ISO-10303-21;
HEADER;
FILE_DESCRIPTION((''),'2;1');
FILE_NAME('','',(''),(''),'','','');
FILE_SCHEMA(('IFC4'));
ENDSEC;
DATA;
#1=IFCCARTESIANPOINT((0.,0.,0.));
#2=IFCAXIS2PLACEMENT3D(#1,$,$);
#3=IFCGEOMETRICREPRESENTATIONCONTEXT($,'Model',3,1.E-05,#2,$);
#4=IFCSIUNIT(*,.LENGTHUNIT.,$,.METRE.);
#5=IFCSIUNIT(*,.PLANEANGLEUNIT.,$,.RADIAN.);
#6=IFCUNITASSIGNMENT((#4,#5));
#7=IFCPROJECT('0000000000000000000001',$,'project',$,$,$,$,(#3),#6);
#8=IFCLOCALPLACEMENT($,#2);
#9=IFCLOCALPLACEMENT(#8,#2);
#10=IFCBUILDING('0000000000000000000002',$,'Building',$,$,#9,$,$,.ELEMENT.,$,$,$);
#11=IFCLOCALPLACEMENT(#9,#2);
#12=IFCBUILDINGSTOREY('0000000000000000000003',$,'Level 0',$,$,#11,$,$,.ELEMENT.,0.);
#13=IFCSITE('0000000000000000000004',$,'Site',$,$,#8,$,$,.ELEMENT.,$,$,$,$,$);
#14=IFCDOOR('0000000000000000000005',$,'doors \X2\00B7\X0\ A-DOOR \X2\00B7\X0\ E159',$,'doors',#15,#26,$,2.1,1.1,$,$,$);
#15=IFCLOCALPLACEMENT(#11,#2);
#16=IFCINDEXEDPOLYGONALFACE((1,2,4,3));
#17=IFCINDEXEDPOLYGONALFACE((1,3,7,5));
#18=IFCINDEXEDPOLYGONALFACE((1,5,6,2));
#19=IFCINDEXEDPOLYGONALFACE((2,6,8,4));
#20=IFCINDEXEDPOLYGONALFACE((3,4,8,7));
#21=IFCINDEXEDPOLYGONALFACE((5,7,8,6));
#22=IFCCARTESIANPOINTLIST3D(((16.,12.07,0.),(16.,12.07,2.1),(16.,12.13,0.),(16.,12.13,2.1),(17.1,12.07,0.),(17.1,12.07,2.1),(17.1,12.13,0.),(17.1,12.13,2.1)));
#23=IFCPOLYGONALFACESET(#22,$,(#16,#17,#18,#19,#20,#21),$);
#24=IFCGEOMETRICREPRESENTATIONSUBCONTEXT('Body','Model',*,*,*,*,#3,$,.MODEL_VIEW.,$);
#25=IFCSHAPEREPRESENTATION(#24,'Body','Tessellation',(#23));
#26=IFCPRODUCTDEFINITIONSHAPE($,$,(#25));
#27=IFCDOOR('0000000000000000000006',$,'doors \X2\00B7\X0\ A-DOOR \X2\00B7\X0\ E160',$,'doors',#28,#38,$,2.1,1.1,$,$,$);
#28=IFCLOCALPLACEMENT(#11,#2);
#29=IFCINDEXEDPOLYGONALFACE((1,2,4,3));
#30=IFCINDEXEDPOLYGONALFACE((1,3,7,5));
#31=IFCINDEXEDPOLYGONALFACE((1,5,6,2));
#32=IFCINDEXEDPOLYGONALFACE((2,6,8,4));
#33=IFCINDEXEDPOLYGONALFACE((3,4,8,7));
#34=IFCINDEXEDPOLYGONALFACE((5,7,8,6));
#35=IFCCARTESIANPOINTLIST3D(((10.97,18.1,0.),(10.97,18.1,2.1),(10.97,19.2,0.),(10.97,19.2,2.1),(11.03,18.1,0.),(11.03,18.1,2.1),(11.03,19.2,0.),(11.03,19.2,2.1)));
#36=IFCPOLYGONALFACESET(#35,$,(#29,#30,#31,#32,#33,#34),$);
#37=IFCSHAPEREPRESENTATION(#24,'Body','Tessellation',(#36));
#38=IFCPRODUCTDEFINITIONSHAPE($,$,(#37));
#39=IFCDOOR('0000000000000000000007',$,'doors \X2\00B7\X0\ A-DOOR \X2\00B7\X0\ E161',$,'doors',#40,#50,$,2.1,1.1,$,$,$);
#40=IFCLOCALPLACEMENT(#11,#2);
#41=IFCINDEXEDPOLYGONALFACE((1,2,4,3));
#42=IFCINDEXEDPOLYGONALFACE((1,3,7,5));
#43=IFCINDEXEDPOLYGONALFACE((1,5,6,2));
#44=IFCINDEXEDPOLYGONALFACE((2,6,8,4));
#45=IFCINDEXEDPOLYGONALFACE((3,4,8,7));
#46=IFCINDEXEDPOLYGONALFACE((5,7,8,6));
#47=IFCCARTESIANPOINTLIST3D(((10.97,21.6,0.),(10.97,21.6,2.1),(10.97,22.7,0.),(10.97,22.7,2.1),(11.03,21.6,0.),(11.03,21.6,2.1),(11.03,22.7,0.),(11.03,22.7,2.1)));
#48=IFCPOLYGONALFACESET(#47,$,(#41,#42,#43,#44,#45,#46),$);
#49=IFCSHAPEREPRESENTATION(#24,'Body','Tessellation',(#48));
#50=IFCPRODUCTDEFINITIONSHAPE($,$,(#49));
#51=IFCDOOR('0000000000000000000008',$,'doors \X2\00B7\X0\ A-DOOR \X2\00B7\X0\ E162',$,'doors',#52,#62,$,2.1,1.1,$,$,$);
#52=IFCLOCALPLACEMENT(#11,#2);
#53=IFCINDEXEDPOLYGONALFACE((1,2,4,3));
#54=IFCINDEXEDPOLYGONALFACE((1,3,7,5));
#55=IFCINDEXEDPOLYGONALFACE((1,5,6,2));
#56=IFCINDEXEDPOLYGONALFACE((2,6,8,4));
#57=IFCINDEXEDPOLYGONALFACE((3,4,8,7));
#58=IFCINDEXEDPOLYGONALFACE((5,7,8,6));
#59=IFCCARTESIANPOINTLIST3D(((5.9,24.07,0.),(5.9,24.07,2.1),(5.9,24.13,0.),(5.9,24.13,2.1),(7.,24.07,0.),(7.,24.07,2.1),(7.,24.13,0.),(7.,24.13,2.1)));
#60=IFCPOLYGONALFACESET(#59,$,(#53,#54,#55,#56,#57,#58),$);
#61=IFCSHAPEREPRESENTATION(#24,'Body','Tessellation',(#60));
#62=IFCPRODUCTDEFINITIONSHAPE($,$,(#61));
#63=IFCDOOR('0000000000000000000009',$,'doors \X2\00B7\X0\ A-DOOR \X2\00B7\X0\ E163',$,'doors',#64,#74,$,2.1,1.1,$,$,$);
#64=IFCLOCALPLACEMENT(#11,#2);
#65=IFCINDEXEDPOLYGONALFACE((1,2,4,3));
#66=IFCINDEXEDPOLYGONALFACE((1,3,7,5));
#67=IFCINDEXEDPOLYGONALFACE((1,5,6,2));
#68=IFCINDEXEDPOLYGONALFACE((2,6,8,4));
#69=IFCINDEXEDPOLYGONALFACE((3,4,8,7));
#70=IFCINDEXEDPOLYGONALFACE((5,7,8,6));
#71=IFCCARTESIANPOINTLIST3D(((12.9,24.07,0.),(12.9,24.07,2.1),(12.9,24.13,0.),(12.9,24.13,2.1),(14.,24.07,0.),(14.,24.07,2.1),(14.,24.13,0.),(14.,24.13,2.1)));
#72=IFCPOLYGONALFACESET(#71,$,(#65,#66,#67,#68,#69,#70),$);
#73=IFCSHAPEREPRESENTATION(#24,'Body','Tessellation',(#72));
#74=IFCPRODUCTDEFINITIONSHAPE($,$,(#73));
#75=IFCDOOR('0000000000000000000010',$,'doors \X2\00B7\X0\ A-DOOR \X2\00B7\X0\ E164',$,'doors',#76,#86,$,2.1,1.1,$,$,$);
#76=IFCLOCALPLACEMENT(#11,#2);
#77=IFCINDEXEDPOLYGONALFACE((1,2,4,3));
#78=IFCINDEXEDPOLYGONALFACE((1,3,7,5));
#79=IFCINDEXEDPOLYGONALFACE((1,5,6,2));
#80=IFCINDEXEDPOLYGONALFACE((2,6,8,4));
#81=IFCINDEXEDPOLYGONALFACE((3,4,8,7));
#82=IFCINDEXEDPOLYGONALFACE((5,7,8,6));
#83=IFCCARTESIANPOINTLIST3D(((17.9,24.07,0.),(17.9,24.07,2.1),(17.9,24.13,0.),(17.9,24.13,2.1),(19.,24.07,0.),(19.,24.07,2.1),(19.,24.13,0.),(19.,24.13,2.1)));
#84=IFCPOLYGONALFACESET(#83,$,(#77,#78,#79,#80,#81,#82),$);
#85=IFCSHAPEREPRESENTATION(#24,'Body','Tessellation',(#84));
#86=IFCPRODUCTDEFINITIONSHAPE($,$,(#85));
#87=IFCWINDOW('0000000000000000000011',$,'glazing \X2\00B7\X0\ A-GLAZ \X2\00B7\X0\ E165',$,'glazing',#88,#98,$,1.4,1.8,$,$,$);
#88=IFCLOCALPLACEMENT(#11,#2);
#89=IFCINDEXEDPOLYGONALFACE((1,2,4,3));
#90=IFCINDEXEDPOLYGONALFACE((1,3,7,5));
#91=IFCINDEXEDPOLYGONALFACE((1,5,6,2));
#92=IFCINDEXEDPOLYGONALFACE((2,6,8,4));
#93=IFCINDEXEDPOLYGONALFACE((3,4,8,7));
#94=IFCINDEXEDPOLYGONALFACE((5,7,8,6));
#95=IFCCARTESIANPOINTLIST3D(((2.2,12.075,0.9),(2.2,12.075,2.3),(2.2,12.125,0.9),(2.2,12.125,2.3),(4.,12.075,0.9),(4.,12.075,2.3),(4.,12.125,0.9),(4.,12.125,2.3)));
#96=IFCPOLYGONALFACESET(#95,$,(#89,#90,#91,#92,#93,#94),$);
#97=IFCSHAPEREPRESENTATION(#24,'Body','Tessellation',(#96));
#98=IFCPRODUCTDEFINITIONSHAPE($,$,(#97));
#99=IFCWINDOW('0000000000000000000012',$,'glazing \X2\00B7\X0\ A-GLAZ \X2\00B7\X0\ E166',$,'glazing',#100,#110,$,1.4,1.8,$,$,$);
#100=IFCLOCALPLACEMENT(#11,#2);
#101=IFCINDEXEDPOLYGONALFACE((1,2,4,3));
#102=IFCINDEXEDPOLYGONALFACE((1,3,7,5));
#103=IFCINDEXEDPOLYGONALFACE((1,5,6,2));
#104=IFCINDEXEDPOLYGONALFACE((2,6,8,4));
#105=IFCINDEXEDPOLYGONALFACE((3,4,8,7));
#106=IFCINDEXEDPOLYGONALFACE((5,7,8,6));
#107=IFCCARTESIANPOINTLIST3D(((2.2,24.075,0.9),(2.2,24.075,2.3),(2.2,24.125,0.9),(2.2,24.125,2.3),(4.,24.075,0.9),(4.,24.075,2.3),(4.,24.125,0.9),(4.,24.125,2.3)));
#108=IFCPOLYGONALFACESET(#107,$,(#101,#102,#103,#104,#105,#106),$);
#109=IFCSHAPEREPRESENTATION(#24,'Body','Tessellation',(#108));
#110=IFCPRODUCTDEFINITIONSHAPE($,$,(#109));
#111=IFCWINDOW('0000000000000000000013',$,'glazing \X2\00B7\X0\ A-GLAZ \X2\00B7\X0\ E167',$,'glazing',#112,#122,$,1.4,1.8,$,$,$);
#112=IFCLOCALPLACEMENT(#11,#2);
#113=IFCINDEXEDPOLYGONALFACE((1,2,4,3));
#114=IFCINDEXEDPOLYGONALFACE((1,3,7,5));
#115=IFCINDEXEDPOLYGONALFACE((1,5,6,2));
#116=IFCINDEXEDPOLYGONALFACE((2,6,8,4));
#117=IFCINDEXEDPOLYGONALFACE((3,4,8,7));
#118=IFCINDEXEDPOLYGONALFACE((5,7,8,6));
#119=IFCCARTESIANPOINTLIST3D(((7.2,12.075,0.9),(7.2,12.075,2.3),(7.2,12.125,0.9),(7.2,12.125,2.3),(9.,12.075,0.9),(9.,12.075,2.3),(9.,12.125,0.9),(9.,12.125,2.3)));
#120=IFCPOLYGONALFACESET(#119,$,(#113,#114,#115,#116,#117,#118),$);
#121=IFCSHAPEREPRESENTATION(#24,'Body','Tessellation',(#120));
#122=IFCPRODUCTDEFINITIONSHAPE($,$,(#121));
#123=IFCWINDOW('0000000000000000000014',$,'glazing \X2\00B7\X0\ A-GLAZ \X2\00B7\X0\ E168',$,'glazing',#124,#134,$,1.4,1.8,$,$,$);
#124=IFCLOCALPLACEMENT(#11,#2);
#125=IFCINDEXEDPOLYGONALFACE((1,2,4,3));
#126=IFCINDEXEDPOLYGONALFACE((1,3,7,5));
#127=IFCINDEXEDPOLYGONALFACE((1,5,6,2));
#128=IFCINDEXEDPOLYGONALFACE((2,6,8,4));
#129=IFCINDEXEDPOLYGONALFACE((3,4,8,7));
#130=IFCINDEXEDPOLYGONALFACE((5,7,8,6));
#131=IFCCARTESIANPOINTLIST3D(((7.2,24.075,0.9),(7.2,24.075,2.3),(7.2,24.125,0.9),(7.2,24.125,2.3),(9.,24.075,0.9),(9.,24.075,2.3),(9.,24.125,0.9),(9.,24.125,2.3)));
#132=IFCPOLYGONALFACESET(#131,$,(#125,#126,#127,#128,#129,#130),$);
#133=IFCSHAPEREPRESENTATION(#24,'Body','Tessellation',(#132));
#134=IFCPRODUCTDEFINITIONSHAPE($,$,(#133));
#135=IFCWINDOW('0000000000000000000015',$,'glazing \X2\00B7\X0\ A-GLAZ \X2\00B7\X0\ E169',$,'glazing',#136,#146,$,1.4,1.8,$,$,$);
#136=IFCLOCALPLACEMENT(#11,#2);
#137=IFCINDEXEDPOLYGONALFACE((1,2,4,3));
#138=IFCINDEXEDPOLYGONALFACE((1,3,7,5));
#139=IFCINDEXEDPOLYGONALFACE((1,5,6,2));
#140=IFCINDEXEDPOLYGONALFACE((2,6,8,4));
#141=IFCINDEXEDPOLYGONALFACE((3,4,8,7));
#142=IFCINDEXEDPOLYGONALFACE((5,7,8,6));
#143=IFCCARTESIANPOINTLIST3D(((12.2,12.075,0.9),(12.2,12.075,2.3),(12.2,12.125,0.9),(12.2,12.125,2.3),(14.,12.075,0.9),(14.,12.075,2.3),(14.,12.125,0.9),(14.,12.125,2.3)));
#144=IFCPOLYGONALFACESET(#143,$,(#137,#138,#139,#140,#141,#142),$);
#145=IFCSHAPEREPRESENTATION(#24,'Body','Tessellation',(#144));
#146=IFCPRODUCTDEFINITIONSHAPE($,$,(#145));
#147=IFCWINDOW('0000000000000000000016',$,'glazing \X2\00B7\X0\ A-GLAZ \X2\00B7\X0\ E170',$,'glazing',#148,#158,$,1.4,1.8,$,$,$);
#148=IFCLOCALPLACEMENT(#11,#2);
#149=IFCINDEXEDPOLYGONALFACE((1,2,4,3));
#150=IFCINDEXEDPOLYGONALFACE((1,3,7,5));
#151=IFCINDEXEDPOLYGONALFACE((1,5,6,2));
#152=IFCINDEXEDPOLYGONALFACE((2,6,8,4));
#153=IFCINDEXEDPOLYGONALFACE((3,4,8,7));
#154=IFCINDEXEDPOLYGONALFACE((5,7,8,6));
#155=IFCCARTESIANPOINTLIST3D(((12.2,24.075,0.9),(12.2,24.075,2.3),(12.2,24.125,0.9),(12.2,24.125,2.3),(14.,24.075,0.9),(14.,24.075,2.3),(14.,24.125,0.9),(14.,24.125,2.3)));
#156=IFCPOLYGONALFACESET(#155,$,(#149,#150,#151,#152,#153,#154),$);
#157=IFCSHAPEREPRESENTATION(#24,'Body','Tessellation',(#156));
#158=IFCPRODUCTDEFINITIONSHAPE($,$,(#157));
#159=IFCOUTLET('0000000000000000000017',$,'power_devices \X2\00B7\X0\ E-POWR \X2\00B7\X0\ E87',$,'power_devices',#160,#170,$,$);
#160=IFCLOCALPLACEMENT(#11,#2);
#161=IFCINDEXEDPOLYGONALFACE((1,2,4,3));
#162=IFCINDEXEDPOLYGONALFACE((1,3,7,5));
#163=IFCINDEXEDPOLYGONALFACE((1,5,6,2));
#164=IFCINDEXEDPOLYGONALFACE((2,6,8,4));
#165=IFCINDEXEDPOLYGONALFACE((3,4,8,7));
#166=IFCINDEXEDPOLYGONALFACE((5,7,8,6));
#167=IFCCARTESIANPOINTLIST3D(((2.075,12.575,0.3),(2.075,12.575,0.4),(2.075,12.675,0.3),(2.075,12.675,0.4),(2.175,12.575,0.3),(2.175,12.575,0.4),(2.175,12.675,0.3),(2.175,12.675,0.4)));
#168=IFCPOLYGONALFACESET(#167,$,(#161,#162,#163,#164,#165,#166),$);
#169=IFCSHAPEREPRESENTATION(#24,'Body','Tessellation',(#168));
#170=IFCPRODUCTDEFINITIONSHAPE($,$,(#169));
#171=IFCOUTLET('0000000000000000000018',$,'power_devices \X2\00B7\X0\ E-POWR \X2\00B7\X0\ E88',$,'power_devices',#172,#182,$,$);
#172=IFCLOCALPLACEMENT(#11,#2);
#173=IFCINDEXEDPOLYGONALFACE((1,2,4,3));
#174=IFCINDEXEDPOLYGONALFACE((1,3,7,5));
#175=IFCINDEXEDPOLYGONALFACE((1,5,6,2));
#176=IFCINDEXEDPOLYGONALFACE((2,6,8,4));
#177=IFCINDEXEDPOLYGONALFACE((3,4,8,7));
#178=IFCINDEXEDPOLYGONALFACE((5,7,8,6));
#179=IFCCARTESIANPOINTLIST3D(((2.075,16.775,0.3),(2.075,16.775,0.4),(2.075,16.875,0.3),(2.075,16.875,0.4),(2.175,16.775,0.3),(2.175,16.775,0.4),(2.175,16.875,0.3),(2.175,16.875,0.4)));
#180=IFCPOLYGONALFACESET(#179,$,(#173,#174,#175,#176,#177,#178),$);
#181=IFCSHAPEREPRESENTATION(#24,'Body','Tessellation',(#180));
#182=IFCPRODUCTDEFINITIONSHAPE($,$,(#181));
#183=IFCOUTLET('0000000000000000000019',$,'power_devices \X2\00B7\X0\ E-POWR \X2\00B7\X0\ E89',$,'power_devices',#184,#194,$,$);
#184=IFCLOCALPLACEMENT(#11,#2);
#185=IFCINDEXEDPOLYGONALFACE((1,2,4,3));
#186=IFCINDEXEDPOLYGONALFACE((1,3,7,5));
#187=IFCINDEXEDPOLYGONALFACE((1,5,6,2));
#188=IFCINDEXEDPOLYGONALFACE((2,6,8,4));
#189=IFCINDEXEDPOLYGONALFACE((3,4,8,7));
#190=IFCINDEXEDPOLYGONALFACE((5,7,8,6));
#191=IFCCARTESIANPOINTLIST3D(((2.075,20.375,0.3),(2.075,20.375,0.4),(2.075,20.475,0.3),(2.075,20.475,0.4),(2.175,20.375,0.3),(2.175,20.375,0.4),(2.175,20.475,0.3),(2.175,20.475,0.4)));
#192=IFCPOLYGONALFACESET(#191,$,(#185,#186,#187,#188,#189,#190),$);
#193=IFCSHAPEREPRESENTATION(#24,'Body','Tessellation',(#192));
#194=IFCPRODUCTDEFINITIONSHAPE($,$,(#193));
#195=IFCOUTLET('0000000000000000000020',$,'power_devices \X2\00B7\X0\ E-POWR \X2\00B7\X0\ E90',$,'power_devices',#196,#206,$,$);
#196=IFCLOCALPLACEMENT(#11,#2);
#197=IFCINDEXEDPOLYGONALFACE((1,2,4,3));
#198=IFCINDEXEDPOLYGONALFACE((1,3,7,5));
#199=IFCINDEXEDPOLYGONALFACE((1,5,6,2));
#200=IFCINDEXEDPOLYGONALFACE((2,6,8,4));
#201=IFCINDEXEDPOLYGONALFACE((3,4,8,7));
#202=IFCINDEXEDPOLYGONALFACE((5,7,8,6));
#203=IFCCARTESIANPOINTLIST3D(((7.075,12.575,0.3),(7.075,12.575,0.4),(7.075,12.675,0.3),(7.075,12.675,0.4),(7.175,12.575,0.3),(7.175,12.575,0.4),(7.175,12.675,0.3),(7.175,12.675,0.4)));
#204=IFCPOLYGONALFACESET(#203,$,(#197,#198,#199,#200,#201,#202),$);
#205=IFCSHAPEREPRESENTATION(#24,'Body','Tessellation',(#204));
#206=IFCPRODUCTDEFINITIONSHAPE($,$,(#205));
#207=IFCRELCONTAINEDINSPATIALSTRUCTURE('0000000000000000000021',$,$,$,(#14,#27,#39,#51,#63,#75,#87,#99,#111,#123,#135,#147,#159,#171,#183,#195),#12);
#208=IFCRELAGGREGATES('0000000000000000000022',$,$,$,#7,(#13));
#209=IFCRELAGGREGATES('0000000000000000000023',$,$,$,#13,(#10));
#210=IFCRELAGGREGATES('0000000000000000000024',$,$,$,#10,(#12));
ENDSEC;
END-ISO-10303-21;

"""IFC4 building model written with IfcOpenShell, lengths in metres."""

from ifc_helpers import new_model, si_unit, frame, origin, place, context, subcontext, project, spatial, polyline, outline, extrude, element, save


model = new_model("IFC4")

# Units and contexts
model_context = context("Model", 3, precision=1e-05, world=origin())
body_context = subcontext(model_context, "Body", "Model", "MODEL_VIEW")
ifc_project = project(units=[si_unit("LENGTHUNIT", "METRE"), si_unit("PLANEANGLEUNIT", "RADIAN")], contexts=[model_context])

# Site, building, storey
site_placement = place(None, origin())
site = spatial("IfcSite", under=ifc_project, at=site_placement, Name="Site", CompositionType="ELEMENT")
building_placement = place(site_placement, origin())
building = spatial("IfcBuilding", under=site, at=building_placement, Name="Building", CompositionType="ELEMENT")
storey_placement = place(building_placement, origin())
storey = spatial("IfcBuildingStorey", under=building, at=storey_placement, Name="Level 0", CompositionType="ELEMENT", Elevation=0.0)

# Doors
door_1_placement = place(storey_placement, origin())
element("IfcDoor", 1, at=door_1_placement, inside=storey, Name="doors · A-DOOR · E159", ObjectType="doors", OverallHeight=2.1, OverallWidth=1.1, context=body_context, shape_type="SweptSolid", body=[
    extrude(outline(polyline([(16.0, 12.07), (17.1, 12.07), (17.1, 12.13), (16.0, 12.13), (16.0, 12.07)])), origin(), (0.0, 0.0, 1.0), 2.1),
])
door_2_placement = place(storey_placement, origin())
element("IfcDoor", 2, at=door_2_placement, inside=storey, Name="doors · A-DOOR · E160", ObjectType="doors", OverallHeight=2.1, OverallWidth=1.1, context=body_context, shape_type="SweptSolid", body=[
    extrude(outline(polyline([(11.03, 18.1), (11.03, 19.2), (10.97, 19.2), (10.97, 18.1), (11.03, 18.1)])), origin(), (0.0, 0.0, 1.0), 2.1),
])
door_3_placement = place(storey_placement, origin())
element("IfcDoor", 3, at=door_3_placement, inside=storey, Name="doors · A-DOOR · E161", ObjectType="doors", OverallHeight=2.1, OverallWidth=1.1, context=body_context, shape_type="SweptSolid", body=[
    extrude(outline(polyline([(11.03, 21.6), (11.03, 22.7), (10.97, 22.7), (10.97, 21.6), (11.03, 21.6)])), origin(), (0.0, 0.0, 1.0), 2.1),
])
door_4_placement = place(storey_placement, origin())
element("IfcDoor", 4, at=door_4_placement, inside=storey, Name="doors · A-DOOR · E162", ObjectType="doors", OverallHeight=2.1, OverallWidth=1.1, context=body_context, shape_type="SweptSolid", body=[
    extrude(outline(polyline([(7.0, 24.13), (5.9, 24.13), (5.9, 24.07), (7.0, 24.07), (7.0, 24.13)])), origin(), (0.0, 0.0, 1.0), 2.1),
])
door_5_placement = place(storey_placement, origin())
element("IfcDoor", 5, at=door_5_placement, inside=storey, Name="doors · A-DOOR · E163", ObjectType="doors", OverallHeight=2.1, OverallWidth=1.1, context=body_context, shape_type="SweptSolid", body=[
    extrude(outline(polyline([(14.0, 24.13), (12.9, 24.13), (12.9, 24.07), (14.0, 24.07), (14.0, 24.13)])), origin(), (0.0, 0.0, 1.0), 2.1),
])
door_6_placement = place(storey_placement, origin())
element("IfcDoor", 6, at=door_6_placement, inside=storey, Name="doors · A-DOOR · E164", ObjectType="doors", OverallHeight=2.1, OverallWidth=1.1, context=body_context, shape_type="SweptSolid", body=[
    extrude(outline(polyline([(19.0, 24.13), (17.9, 24.13), (17.9, 24.07), (19.0, 24.07), (19.0, 24.13)])), origin(), (0.0, 0.0, 1.0), 2.1),
])

# Windows
window_1_placement = place(storey_placement, frame((0.0, 0.0, 0.9)))
element("IfcWindow", 7, at=window_1_placement, inside=storey, Name="glazing · A-GLAZ · E165", ObjectType="glazing", OverallHeight=1.4, OverallWidth=1.8, context=body_context, shape_type="SweptSolid", body=[
    extrude(outline(polyline([(2.2, 12.075), (4.0, 12.075), (4.0, 12.125), (2.2, 12.125), (2.2, 12.075)])), origin(), (0.0, 0.0, 1.0), 1.4),
])
window_2_placement = place(storey_placement, frame((0.0, 0.0, 0.9)))
element("IfcWindow", 8, at=window_2_placement, inside=storey, Name="glazing · A-GLAZ · E166", ObjectType="glazing", OverallHeight=1.4, OverallWidth=1.8, context=body_context, shape_type="SweptSolid", body=[
    extrude(outline(polyline([(4.0, 24.125), (2.2, 24.125), (2.2, 24.075), (4.0, 24.075), (4.0, 24.125)])), origin(), (0.0, 0.0, 1.0), 1.4),
])
window_3_placement = place(storey_placement, frame((0.0, 0.0, 0.9)))
element("IfcWindow", 9, at=window_3_placement, inside=storey, Name="glazing · A-GLAZ · E167", ObjectType="glazing", OverallHeight=1.4, OverallWidth=1.8, context=body_context, shape_type="SweptSolid", body=[
    extrude(outline(polyline([(7.2, 12.075), (9.0, 12.075), (9.0, 12.125), (7.2, 12.125), (7.2, 12.075)])), origin(), (0.0, 0.0, 1.0), 1.4),
])
window_4_placement = place(storey_placement, frame((0.0, 0.0, 0.9)))
element("IfcWindow", 10, at=window_4_placement, inside=storey, Name="glazing · A-GLAZ · E168", ObjectType="glazing", OverallHeight=1.4, OverallWidth=1.8, context=body_context, shape_type="SweptSolid", body=[
    extrude(outline(polyline([(9.0, 24.125), (7.2, 24.125), (7.2, 24.075), (9.0, 24.075), (9.0, 24.125)])), origin(), (0.0, 0.0, 1.0), 1.4),
])
window_5_placement = place(storey_placement, frame((0.0, 0.0, 0.9)))
element("IfcWindow", 11, at=window_5_placement, inside=storey, Name="glazing · A-GLAZ · E169", ObjectType="glazing", OverallHeight=1.4, OverallWidth=1.8, context=body_context, shape_type="SweptSolid", body=[
    extrude(outline(polyline([(12.2, 12.075), (14.0, 12.075), (14.0, 12.125), (12.2, 12.125), (12.2, 12.075)])), origin(), (0.0, 0.0, 1.0), 1.4),
])
window_6_placement = place(storey_placement, frame((0.0, 0.0, 0.9)))
element("IfcWindow", 12, at=window_6_placement, inside=storey, Name="glazing · A-GLAZ · E170", ObjectType="glazing", OverallHeight=1.4, OverallWidth=1.8, context=body_context, shape_type="SweptSolid", body=[
    extrude(outline(polyline([(14.0, 24.125), (12.2, 24.125), (12.2, 24.075), (14.0, 24.075), (14.0, 24.125)])), origin(), (0.0, 0.0, 1.0), 1.4),
])

# Outlets
outlet_1_placement = place(storey_placement, frame((0.0, 0.0, 0.3)))
element("IfcOutlet", 13, at=outlet_1_placement, inside=storey, Name="power_devices · E-POWR · E87", ObjectType="power_devices", context=body_context, shape_type="SweptSolid", body=[
    extrude(outline(polyline([(2.075, 12.575), (2.175, 12.575), (2.175, 12.675), (2.075, 12.675), (2.075, 12.575)])), origin(), (0.0, 0.0, 1.0), 0.1),
])
outlet_2_placement = place(storey_placement, frame((0.0, 0.0, 0.3)))
element("IfcOutlet", 14, at=outlet_2_placement, inside=storey, Name="power_devices · E-POWR · E88", ObjectType="power_devices", context=body_context, shape_type="SweptSolid", body=[
    extrude(outline(polyline([(2.075, 16.775), (2.175, 16.775), (2.175, 16.875), (2.075, 16.875), (2.075, 16.775)])), origin(), (0.0, 0.0, 1.0), 0.1),
])
outlet_3_placement = place(storey_placement, frame((0.0, 0.0, 0.3)))
element("IfcOutlet", 15, at=outlet_3_placement, inside=storey, Name="power_devices · E-POWR · E89", ObjectType="power_devices", context=body_context, shape_type="SweptSolid", body=[
    extrude(outline(polyline([(2.075, 20.375), (2.175, 20.375), (2.175, 20.475), (2.075, 20.475), (2.075, 20.375)])), origin(), (0.0, 0.0, 1.0), 0.1),
])
outlet_4_placement = place(storey_placement, frame((0.0, 0.0, 0.3)))
element("IfcOutlet", 16, at=outlet_4_placement, inside=storey, Name="power_devices · E-POWR · E90", ObjectType="power_devices", context=body_context, shape_type="SweptSolid", body=[
    extrude(outline(polyline([(7.075, 12.575), (7.175, 12.575), (7.175, 12.675), (7.075, 12.675), (7.075, 12.575)])), origin(), (0.0, 0.0, 1.0), 0.1),
])

save(model, "model.ifc")
